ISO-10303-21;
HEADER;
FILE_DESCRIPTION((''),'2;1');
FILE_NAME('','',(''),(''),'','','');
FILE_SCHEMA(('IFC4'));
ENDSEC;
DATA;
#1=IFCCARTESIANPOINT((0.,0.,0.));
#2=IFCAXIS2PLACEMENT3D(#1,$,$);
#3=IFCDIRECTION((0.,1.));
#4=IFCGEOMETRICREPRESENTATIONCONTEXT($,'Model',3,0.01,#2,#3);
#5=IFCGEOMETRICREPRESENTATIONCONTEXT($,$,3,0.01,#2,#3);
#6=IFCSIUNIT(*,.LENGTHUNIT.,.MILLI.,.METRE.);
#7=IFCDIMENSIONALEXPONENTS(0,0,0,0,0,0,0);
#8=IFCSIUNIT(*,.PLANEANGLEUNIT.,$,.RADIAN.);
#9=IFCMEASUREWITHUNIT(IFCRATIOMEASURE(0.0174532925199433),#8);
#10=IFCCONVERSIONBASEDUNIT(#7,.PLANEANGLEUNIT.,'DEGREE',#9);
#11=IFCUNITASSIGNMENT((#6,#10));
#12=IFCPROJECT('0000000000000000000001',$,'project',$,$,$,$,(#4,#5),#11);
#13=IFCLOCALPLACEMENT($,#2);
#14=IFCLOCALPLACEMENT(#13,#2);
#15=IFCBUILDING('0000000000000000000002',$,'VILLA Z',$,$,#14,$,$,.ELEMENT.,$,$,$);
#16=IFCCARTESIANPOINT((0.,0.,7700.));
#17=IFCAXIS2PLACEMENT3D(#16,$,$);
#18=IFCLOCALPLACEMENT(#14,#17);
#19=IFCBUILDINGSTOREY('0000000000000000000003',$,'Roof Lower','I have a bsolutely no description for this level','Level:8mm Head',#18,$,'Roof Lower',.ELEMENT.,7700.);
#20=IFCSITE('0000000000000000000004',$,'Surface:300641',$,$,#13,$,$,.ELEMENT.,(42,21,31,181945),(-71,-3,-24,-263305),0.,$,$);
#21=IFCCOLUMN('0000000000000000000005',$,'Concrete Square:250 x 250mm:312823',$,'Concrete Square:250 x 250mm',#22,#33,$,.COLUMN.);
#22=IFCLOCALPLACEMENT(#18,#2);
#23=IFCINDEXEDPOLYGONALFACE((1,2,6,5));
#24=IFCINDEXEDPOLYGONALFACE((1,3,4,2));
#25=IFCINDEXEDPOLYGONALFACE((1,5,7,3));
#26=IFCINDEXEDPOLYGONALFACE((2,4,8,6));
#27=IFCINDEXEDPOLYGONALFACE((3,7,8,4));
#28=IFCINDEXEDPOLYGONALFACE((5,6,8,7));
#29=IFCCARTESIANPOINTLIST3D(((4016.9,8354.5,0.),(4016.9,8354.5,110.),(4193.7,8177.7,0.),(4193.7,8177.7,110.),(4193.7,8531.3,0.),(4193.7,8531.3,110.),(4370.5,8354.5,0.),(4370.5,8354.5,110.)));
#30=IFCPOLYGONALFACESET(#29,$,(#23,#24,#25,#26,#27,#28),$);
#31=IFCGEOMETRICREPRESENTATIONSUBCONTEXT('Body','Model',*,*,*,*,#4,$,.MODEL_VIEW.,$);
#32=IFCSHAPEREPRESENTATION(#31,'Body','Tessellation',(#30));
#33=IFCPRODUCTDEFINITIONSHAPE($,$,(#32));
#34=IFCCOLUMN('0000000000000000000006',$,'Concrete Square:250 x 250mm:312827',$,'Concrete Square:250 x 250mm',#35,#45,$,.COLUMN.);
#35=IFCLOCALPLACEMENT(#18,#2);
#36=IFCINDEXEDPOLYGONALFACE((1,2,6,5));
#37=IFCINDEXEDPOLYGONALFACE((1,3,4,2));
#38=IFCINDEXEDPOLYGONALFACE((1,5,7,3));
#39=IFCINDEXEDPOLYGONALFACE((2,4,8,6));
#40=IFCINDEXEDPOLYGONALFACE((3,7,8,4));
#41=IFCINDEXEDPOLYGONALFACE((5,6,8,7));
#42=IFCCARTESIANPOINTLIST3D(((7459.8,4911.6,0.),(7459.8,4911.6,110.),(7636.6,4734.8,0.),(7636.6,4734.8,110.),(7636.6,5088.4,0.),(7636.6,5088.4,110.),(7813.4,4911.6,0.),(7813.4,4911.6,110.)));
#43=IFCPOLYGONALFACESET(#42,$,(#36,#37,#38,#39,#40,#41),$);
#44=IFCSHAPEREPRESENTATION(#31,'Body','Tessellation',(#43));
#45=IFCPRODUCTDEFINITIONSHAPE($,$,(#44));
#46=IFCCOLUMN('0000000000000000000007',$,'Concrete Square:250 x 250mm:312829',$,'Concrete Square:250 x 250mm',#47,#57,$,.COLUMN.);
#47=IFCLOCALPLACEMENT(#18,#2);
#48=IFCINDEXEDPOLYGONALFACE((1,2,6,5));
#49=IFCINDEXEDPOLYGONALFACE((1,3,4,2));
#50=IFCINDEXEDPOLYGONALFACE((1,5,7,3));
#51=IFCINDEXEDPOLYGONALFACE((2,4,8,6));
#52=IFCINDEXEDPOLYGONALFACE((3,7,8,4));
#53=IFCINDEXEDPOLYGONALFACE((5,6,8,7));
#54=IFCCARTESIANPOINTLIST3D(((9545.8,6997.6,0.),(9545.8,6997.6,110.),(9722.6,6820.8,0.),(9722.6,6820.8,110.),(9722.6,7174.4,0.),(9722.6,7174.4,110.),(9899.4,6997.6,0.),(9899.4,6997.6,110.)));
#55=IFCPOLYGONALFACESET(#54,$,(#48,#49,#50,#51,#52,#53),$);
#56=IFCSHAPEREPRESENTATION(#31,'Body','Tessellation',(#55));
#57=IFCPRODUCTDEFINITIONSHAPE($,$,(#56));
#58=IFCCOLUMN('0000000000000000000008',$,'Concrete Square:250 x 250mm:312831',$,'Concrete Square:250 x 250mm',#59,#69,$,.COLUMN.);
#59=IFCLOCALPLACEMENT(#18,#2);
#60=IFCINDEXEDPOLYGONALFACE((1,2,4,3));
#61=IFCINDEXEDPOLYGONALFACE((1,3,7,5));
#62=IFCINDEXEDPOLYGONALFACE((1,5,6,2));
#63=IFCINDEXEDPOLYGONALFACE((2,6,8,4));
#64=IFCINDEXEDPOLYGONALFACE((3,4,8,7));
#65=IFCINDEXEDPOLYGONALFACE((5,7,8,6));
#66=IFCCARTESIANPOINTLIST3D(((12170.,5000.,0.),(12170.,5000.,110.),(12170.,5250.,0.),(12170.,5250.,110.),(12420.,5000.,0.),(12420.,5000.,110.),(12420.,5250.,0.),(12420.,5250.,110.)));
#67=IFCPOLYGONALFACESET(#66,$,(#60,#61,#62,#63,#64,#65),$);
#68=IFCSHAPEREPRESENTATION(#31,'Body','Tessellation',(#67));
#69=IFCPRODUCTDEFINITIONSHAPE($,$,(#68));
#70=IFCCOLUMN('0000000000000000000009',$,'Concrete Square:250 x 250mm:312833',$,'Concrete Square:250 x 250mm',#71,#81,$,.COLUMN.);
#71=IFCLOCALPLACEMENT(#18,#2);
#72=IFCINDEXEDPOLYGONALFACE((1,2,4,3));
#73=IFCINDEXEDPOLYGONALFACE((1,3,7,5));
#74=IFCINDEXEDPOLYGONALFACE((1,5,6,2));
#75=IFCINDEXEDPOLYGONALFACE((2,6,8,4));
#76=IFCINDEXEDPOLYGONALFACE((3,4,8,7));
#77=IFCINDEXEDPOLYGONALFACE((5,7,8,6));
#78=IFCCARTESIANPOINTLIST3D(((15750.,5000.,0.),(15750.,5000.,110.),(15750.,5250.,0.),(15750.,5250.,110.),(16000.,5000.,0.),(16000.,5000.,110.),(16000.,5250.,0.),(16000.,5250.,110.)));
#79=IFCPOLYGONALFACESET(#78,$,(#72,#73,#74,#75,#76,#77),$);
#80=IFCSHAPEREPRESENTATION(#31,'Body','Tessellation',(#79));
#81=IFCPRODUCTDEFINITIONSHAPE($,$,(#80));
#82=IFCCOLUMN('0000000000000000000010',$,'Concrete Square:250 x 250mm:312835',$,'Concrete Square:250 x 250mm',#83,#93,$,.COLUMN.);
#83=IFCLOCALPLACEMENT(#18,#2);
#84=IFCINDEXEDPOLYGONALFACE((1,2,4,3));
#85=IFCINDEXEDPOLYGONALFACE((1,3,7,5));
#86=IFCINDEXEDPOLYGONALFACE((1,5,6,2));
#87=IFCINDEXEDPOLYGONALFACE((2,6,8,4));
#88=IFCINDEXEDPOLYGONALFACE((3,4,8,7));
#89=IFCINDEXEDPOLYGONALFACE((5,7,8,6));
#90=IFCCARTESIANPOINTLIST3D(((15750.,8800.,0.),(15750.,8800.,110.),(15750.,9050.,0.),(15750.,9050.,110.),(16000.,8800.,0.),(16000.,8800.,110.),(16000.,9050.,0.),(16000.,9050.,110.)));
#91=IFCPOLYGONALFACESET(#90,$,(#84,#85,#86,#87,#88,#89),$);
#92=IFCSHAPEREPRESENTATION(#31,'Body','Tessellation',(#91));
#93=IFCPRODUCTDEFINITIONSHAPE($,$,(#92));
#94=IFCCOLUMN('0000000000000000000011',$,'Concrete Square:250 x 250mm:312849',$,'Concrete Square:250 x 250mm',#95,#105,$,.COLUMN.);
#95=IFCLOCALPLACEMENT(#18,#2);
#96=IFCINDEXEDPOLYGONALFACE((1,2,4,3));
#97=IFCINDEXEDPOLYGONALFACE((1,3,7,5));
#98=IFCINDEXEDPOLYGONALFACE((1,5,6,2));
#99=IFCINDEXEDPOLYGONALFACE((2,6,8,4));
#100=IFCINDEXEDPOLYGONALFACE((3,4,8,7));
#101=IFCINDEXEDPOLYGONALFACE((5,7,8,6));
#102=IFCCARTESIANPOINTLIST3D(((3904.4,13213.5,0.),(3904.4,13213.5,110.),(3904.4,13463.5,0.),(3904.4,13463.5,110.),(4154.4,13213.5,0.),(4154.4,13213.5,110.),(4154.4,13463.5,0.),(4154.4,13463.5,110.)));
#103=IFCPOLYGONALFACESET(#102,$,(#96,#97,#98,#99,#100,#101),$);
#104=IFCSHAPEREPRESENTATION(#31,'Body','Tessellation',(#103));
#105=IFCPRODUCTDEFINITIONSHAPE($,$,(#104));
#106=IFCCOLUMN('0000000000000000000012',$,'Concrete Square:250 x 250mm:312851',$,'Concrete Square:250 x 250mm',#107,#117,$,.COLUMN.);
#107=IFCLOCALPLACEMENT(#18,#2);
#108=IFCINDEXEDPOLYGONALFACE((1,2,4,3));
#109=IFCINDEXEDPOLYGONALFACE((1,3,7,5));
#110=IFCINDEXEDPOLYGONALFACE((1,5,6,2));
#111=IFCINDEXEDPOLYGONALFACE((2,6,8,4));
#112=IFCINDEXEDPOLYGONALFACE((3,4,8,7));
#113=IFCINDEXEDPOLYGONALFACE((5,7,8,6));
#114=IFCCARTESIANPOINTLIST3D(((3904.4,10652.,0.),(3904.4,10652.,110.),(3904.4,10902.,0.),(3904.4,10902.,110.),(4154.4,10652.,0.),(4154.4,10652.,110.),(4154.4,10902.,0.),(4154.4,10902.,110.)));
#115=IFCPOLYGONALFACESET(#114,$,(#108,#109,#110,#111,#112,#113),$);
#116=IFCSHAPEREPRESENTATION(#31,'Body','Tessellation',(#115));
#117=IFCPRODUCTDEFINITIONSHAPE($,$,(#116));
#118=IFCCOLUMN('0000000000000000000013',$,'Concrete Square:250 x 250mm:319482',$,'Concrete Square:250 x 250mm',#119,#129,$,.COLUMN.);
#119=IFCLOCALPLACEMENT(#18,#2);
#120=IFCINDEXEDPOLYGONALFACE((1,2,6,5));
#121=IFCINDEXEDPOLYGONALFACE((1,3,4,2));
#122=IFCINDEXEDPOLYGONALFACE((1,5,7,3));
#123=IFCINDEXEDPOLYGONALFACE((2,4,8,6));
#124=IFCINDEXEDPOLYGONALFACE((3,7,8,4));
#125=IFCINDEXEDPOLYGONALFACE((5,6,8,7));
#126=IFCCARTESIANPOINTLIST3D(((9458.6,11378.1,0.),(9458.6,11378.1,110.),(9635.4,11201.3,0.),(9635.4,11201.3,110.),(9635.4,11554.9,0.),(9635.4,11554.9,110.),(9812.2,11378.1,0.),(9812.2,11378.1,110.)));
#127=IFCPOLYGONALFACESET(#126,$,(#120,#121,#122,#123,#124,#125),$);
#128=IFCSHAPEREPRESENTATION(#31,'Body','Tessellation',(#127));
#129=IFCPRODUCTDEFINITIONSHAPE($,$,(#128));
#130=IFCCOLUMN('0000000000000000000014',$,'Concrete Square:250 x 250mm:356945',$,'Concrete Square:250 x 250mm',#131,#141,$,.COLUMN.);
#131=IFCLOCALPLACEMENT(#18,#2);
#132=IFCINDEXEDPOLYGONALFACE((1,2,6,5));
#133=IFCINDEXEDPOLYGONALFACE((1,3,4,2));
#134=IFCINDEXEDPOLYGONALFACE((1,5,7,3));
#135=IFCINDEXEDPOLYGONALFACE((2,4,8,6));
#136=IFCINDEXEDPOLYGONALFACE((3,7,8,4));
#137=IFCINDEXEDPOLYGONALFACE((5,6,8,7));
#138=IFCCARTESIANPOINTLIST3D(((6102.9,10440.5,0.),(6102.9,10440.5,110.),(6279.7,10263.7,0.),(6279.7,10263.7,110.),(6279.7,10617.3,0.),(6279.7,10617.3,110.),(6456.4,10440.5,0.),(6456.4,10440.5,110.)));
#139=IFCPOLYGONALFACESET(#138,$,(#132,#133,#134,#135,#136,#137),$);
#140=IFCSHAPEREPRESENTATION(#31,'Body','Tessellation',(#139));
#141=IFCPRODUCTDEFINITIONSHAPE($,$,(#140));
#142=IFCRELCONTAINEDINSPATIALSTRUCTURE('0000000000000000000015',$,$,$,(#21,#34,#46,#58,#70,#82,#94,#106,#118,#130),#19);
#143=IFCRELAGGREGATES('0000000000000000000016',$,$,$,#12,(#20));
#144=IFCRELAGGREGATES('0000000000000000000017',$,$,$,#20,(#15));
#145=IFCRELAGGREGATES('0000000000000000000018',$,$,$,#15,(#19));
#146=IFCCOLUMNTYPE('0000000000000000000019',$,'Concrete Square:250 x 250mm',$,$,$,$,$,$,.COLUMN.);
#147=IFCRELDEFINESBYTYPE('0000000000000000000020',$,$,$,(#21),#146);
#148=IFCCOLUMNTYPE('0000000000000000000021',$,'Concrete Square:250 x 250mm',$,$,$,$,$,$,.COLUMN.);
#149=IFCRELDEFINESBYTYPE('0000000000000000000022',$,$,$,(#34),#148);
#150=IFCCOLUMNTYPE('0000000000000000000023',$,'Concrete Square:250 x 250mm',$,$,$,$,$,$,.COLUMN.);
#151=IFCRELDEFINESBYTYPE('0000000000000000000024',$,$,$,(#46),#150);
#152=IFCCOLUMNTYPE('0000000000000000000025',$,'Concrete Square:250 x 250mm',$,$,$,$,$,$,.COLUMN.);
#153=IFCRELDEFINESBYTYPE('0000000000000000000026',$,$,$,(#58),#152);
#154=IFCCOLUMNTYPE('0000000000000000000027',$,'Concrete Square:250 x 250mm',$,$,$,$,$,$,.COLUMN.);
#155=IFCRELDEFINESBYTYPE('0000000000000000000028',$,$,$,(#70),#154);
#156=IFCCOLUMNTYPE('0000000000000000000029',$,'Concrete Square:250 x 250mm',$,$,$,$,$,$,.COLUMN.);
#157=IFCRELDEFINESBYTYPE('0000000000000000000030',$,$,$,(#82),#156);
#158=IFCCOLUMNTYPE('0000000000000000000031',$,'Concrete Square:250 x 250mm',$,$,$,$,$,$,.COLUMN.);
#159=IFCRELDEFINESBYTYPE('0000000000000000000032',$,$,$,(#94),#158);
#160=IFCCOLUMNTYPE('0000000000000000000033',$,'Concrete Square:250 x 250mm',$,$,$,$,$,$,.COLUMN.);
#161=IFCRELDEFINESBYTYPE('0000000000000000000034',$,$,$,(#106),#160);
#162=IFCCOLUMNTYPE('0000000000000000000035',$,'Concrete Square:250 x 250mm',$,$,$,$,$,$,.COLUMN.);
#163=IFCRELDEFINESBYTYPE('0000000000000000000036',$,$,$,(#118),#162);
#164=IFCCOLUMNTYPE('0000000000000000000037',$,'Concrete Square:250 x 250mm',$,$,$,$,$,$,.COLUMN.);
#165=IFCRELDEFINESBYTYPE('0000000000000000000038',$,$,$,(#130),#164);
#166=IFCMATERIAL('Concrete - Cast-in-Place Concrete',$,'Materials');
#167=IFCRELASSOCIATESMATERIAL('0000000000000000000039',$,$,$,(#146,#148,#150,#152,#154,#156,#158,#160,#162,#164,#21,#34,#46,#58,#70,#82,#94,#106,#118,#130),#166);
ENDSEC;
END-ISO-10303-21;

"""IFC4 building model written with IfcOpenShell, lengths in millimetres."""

from ifc_helpers import new_model, entity, si_unit, converted_unit, direction, frame, frame_2d, origin, origin_2d_with_axis, place, context, subcontext, project, spatial, rectangle, extrude, source, transform, mapped, material, material_profile, profile_set, profile_usage, type_object, type_shapes, element, save


model = new_model("IFC4")

# Units and contexts
model_context = context("Model", 3, precision=0.01, world=origin(), true_north=direction((0.0, 1.0)))
context_of_model = context(None, 3, precision=0.01, world=origin(), true_north=direction((0.0, 1.0)))
body_context = subcontext(model_context, "Body", "Model", "MODEL_VIEW")
ifc_project = project(units=[si_unit("LENGTHUNIT", "METRE", prefix="MILLI"), converted_unit("PLANEANGLEUNIT", "DEGREE", entity("IfcRatioMeasure", 0.0174532925199433), si_unit("PLANEANGLEUNIT", "RADIAN"), dimensions=[0, 0, 0, 0, 0, 0, 0])], contexts=[model_context, context_of_model])

# Site, building, storey
site_placement = place(None, origin())
site = spatial("IfcSite", under=ifc_project, at=site_placement, Name="Surface:300641", CompositionType="ELEMENT", RefLatitude=(42, 21, 31, 181945), RefLongitude=(-71, -3, -24, -263305), RefElevation=0.0)
building_placement = place(site_placement, origin())
building = spatial("IfcBuilding", under=site, at=building_placement, Name="VILLA Z", CompositionType="ELEMENT")
storey_placement = place(building_placement, frame((0.0, 0.0, 7700.0)))
storey = spatial("IfcBuildingStorey", under=building, at=storey_placement, Name="Roof Lower", Description="I have a bsolutely no description for this level", ObjectType="Level:8mm Head", LongName="Roof Lower", CompositionType="ELEMENT", Elevation=7700.0)

# Columns
ifc_material_1 = material(Name="Concrete - Cast-in-Place Concrete", Category="Materials")
ifc_material_profile_1 = material_profile(ifc_material_1, rectangle(XDim=250.0, YDim=250.0, at=frame_2d((0.0, 0.0), x_axis=(1.0, 0.0))), Name="250 x 250mm")
ifc_profile_set_1 = profile_set([ifc_material_profile_1], Name="250 x 250mm")
ifc_profile_usage_1 = profile_usage(ifc_profile_set_1)
column_type_1 = type_object("IfcColumnType", Name="Concrete Square:250 x 250mm", PredefinedType="COLUMN", material=ifc_profile_set_1)
shared_shape_1 = source(origin(), body_context, "Body", "SweptSolid", [
    extrude(rectangle(XDim=250.0, YDim=250.0, at=frame_2d((0.0, 0.0), x_axis=(1.0, 0.0))), frame((4193.7, 8354.5, 7700.0), z_axis=(0.0, 0.0, 1.0), x_axis=(-0.707107, 0.707107, 0.0)), (0.0, 0.0, 1.0), 110.0),
])
type_shapes(column_type_1, [shared_shape_1])
column_1_placement = place(storey_placement, frame((0.0, 0.0, -7700.0)))
element("IfcColumn", 1, at=column_1_placement, inside=storey, type_object=column_type_1, material=ifc_profile_usage_1, Name="Concrete Square:250 x 250mm:312823", ObjectType="Concrete Square:250 x 250mm", PredefinedType="COLUMN", context=body_context, shape_type="MappedRepresentation", body=[
    mapped(shared_shape_1, transform((0.0, 0.0, 0.0), scale=1.0)),
])
ifc_profile_usage_2 = profile_usage(ifc_profile_set_1)
column_type_2 = type_object("IfcColumnType", Name="Concrete Square:250 x 250mm", PredefinedType="COLUMN", material=ifc_profile_set_1)
shared_shape_2 = source(origin(), body_context, "Body", "SweptSolid", [
    extrude(rectangle(XDim=250.0, YDim=250.0, at=frame_2d((0.0, 0.0), x_axis=(1.0, 0.0))), frame((7636.6, 4911.6, 7700.0), z_axis=(0.0, 0.0, 1.0), x_axis=(-0.707107, 0.707107, 0.0)), (0.0, 0.0, 1.0), 110.0),
])
type_shapes(column_type_2, [shared_shape_2])
column_2_placement = place(storey_placement, frame((0.0, 0.0, -7700.0)))
element("IfcColumn", 2, at=column_2_placement, inside=storey, type_object=column_type_2, material=ifc_profile_usage_2, Name="Concrete Square:250 x 250mm:312827", ObjectType="Concrete Square:250 x 250mm", PredefinedType="COLUMN", context=body_context, shape_type="MappedRepresentation", body=[
    mapped(shared_shape_2, transform((0.0, 0.0, 0.0), scale=1.0)),
])
ifc_profile_usage_3 = profile_usage(ifc_profile_set_1)
column_type_3 = type_object("IfcColumnType", Name="Concrete Square:250 x 250mm", PredefinedType="COLUMN", material=ifc_profile_set_1)
shared_shape_3 = source(origin(), body_context, "Body", "SweptSolid", [
    extrude(rectangle(XDim=250.0, YDim=250.0, at=frame_2d((0.0, 0.0), x_axis=(1.0, 0.0))), frame((9722.6, 6997.6, 7700.0), z_axis=(0.0, 0.0, 1.0), x_axis=(-0.707107, 0.707107, 0.0)), (0.0, 0.0, 1.0), 110.0),
])
type_shapes(column_type_3, [shared_shape_3])
column_3_placement = place(storey_placement, frame((0.0, 0.0, -7700.0)))
element("IfcColumn", 3, at=column_3_placement, inside=storey, type_object=column_type_3, material=ifc_profile_usage_3, Name="Concrete Square:250 x 250mm:312829", ObjectType="Concrete Square:250 x 250mm", PredefinedType="COLUMN", context=body_context, shape_type="MappedRepresentation", body=[
    mapped(shared_shape_3, transform((0.0, 0.0, 0.0), scale=1.0)),
])
ifc_profile_usage_4 = profile_usage(ifc_profile_set_1)
column_type_4 = type_object("IfcColumnType", Name="Concrete Square:250 x 250mm", PredefinedType="COLUMN", material=ifc_profile_set_1)
shared_shape_4 = source(origin(), body_context, "Body", "SweptSolid", [
    extrude(rectangle(XDim=250.0, YDim=250.0, at=origin_2d_with_axis()), frame((12295.0, 5125.0, 7700.0), z_axis=(0.0, 0.0, 1.0), x_axis=(0.0, -1.0, 0.0)), (0.0, 0.0, 1.0), 110.0),
])
type_shapes(column_type_4, [shared_shape_4])
column_4_placement = place(storey_placement, frame((0.0, 0.0, -7700.0)))
element("IfcColumn", 4, at=column_4_placement, inside=storey, type_object=column_type_4, material=ifc_profile_usage_4, Name="Concrete Square:250 x 250mm:312831", ObjectType="Concrete Square:250 x 250mm", PredefinedType="COLUMN", context=body_context, shape_type="MappedRepresentation", body=[
    mapped(shared_shape_4, transform((0.0, 0.0, 0.0), scale=1.0)),
])
ifc_profile_usage_5 = profile_usage(ifc_profile_set_1)
column_type_5 = type_object("IfcColumnType", Name="Concrete Square:250 x 250mm", PredefinedType="COLUMN", material=ifc_profile_set_1)
shared_shape_5 = source(origin(), body_context, "Body", "SweptSolid", [
    extrude(rectangle(XDim=250.0, YDim=250.0, at=origin_2d_with_axis()), frame((15875.0, 5125.0, 7700.0), z_axis=(0.0, 0.0, 1.0), x_axis=(0.0, -1.0, 0.0)), (0.0, 0.0, 1.0), 110.0),
])
type_shapes(column_type_5, [shared_shape_5])
column_5_placement = place(storey_placement, frame((0.0, 0.0, -7700.0)))
element("IfcColumn", 5, at=column_5_placement, inside=storey, type_object=column_type_5, material=ifc_profile_usage_5, Name="Concrete Square:250 x 250mm:312833", ObjectType="Concrete Square:250 x 250mm", PredefinedType="COLUMN", context=body_context, shape_type="MappedRepresentation", body=[
    mapped(shared_shape_5, transform((0.0, 0.0, 0.0), scale=1.0)),
])
ifc_profile_usage_6 = profile_usage(ifc_profile_set_1)
column_type_6 = type_object("IfcColumnType", Name="Concrete Square:250 x 250mm", PredefinedType="COLUMN", material=ifc_profile_set_1)
shared_shape_6 = source(origin(), body_context, "Body", "SweptSolid", [
    extrude(rectangle(XDim=250.0, YDim=250.0, at=frame_2d((0.0, 0.0), x_axis=(1.0, 0.0))), frame((15875.0, 8925.0, 7700.0), z_axis=(0.0, 0.0, 1.0), x_axis=(0.0, -1.0, 0.0)), (0.0, 0.0, 1.0), 110.0),
])
type_shapes(column_type_6, [shared_shape_6])
column_6_placement = place(storey_placement, frame((0.0, 0.0, -7700.0)))
element("IfcColumn", 6, at=column_6_placement, inside=storey, type_object=column_type_6, material=ifc_profile_usage_6, Name="Concrete Square:250 x 250mm:312835", ObjectType="Concrete Square:250 x 250mm", PredefinedType="COLUMN", context=body_context, shape_type="MappedRepresentation", body=[
    mapped(shared_shape_6, transform((0.0, 0.0, 0.0), scale=1.0)),
])
ifc_profile_usage_7 = profile_usage(ifc_profile_set_1)
column_type_7 = type_object("IfcColumnType", Name="Concrete Square:250 x 250mm", PredefinedType="COLUMN", material=ifc_profile_set_1)
shared_shape_7 = source(origin(), body_context, "Body", "SweptSolid", [
    extrude(rectangle(XDim=250.0, YDim=250.0, at=frame_2d((0.0, 0.0), x_axis=(1.0, 0.0))), frame((4029.4, 13338.5, 7700.0), z_axis=(0.0, 0.0, 1.0), x_axis=(0.0, -1.0, 0.0)), (0.0, 0.0, 1.0), 110.0),
])
type_shapes(column_type_7, [shared_shape_7])
column_7_placement = place(storey_placement, frame((0.0, 0.0, -7700.0)))
element("IfcColumn", 7, at=column_7_placement, inside=storey, type_object=column_type_7, material=ifc_profile_usage_7, Name="Concrete Square:250 x 250mm:312849", ObjectType="Concrete Square:250 x 250mm", PredefinedType="COLUMN", context=body_context, shape_type="MappedRepresentation", body=[
    mapped(shared_shape_7, transform((0.0, 0.0, 0.0), scale=1.0)),
])
ifc_profile_usage_8 = profile_usage(ifc_profile_set_1)
column_type_8 = type_object("IfcColumnType", Name="Concrete Square:250 x 250mm", PredefinedType="COLUMN", material=ifc_profile_set_1)
shared_shape_8 = source(origin(), body_context, "Body", "SweptSolid", [
    extrude(rectangle(XDim=250.0, YDim=250.0, at=frame_2d((0.0, 0.0), x_axis=(1.0, 0.0))), frame((4029.4, 10777.0, 7700.0), z_axis=(0.0, 0.0, 1.0), x_axis=(0.0, -1.0, 0.0)), (0.0, 0.0, 1.0), 110.0),
])
type_shapes(column_type_8, [shared_shape_8])
column_8_placement = place(storey_placement, frame((0.0, 0.0, -7700.0)))
element("IfcColumn", 8, at=column_8_placement, inside=storey, type_object=column_type_8, material=ifc_profile_usage_8, Name="Concrete Square:250 x 250mm:312851", ObjectType="Concrete Square:250 x 250mm", PredefinedType="COLUMN", context=body_context, shape_type="MappedRepresentation", body=[
    mapped(shared_shape_8, transform((0.0, 0.0, 0.0), scale=1.0)),
])
ifc_profile_usage_9 = profile_usage(ifc_profile_set_1)
column_type_9 = type_object("IfcColumnType", Name="Concrete Square:250 x 250mm", PredefinedType="COLUMN", material=ifc_profile_set_1)
shared_shape_9 = source(origin(), body_context, "Body", "SweptSolid", [
    extrude(rectangle(XDim=250.0, YDim=250.0, at=frame_2d((0.0, 0.0), x_axis=(1.0, 0.0))), frame((9635.4, 11378.1, 7700.0), z_axis=(0.0, 0.0, 1.0), x_axis=(-0.707107, 0.707107, 0.0)), (0.0, 0.0, 1.0), 110.0),
])
type_shapes(column_type_9, [shared_shape_9])
column_9_placement = place(storey_placement, frame((0.0, 0.0, -7700.0)))
element("IfcColumn", 9, at=column_9_placement, inside=storey, type_object=column_type_9, material=ifc_profile_usage_9, Name="Concrete Square:250 x 250mm:319482", ObjectType="Concrete Square:250 x 250mm", PredefinedType="COLUMN", context=body_context, shape_type="MappedRepresentation", body=[
    mapped(shared_shape_9, transform((0.0, 0.0, 0.0), scale=1.0)),
])
ifc_profile_usage_10 = profile_usage(ifc_profile_set_1)
column_type_10 = type_object("IfcColumnType", Name="Concrete Square:250 x 250mm", PredefinedType="COLUMN", material=ifc_profile_set_1)
shared_shape_10 = source(origin(), body_context, "Body", "SweptSolid", [
    extrude(rectangle(XDim=250.0, YDim=250.0, at=origin_2d_with_axis()), frame((6279.7, 10440.5, 7700.0), z_axis=(0.0, 0.0, 1.0), x_axis=(-0.707107, 0.707107, 0.0)), (0.0, 0.0, 1.0), 110.0),
])
type_shapes(column_type_10, [shared_shape_10])
column_10_placement = place(storey_placement, frame((0.0, 0.0, -7700.0)))
element("IfcColumn", 10, at=column_10_placement, inside=storey, type_object=column_type_10, material=ifc_profile_usage_10, Name="Concrete Square:250 x 250mm:356945", ObjectType="Concrete Square:250 x 250mm", PredefinedType="COLUMN", context=body_context, shape_type="MappedRepresentation", body=[
    mapped(shared_shape_10, transform((0.0, 0.0, 0.0), scale=1.0)),
])

save(model, "model.ifc")
